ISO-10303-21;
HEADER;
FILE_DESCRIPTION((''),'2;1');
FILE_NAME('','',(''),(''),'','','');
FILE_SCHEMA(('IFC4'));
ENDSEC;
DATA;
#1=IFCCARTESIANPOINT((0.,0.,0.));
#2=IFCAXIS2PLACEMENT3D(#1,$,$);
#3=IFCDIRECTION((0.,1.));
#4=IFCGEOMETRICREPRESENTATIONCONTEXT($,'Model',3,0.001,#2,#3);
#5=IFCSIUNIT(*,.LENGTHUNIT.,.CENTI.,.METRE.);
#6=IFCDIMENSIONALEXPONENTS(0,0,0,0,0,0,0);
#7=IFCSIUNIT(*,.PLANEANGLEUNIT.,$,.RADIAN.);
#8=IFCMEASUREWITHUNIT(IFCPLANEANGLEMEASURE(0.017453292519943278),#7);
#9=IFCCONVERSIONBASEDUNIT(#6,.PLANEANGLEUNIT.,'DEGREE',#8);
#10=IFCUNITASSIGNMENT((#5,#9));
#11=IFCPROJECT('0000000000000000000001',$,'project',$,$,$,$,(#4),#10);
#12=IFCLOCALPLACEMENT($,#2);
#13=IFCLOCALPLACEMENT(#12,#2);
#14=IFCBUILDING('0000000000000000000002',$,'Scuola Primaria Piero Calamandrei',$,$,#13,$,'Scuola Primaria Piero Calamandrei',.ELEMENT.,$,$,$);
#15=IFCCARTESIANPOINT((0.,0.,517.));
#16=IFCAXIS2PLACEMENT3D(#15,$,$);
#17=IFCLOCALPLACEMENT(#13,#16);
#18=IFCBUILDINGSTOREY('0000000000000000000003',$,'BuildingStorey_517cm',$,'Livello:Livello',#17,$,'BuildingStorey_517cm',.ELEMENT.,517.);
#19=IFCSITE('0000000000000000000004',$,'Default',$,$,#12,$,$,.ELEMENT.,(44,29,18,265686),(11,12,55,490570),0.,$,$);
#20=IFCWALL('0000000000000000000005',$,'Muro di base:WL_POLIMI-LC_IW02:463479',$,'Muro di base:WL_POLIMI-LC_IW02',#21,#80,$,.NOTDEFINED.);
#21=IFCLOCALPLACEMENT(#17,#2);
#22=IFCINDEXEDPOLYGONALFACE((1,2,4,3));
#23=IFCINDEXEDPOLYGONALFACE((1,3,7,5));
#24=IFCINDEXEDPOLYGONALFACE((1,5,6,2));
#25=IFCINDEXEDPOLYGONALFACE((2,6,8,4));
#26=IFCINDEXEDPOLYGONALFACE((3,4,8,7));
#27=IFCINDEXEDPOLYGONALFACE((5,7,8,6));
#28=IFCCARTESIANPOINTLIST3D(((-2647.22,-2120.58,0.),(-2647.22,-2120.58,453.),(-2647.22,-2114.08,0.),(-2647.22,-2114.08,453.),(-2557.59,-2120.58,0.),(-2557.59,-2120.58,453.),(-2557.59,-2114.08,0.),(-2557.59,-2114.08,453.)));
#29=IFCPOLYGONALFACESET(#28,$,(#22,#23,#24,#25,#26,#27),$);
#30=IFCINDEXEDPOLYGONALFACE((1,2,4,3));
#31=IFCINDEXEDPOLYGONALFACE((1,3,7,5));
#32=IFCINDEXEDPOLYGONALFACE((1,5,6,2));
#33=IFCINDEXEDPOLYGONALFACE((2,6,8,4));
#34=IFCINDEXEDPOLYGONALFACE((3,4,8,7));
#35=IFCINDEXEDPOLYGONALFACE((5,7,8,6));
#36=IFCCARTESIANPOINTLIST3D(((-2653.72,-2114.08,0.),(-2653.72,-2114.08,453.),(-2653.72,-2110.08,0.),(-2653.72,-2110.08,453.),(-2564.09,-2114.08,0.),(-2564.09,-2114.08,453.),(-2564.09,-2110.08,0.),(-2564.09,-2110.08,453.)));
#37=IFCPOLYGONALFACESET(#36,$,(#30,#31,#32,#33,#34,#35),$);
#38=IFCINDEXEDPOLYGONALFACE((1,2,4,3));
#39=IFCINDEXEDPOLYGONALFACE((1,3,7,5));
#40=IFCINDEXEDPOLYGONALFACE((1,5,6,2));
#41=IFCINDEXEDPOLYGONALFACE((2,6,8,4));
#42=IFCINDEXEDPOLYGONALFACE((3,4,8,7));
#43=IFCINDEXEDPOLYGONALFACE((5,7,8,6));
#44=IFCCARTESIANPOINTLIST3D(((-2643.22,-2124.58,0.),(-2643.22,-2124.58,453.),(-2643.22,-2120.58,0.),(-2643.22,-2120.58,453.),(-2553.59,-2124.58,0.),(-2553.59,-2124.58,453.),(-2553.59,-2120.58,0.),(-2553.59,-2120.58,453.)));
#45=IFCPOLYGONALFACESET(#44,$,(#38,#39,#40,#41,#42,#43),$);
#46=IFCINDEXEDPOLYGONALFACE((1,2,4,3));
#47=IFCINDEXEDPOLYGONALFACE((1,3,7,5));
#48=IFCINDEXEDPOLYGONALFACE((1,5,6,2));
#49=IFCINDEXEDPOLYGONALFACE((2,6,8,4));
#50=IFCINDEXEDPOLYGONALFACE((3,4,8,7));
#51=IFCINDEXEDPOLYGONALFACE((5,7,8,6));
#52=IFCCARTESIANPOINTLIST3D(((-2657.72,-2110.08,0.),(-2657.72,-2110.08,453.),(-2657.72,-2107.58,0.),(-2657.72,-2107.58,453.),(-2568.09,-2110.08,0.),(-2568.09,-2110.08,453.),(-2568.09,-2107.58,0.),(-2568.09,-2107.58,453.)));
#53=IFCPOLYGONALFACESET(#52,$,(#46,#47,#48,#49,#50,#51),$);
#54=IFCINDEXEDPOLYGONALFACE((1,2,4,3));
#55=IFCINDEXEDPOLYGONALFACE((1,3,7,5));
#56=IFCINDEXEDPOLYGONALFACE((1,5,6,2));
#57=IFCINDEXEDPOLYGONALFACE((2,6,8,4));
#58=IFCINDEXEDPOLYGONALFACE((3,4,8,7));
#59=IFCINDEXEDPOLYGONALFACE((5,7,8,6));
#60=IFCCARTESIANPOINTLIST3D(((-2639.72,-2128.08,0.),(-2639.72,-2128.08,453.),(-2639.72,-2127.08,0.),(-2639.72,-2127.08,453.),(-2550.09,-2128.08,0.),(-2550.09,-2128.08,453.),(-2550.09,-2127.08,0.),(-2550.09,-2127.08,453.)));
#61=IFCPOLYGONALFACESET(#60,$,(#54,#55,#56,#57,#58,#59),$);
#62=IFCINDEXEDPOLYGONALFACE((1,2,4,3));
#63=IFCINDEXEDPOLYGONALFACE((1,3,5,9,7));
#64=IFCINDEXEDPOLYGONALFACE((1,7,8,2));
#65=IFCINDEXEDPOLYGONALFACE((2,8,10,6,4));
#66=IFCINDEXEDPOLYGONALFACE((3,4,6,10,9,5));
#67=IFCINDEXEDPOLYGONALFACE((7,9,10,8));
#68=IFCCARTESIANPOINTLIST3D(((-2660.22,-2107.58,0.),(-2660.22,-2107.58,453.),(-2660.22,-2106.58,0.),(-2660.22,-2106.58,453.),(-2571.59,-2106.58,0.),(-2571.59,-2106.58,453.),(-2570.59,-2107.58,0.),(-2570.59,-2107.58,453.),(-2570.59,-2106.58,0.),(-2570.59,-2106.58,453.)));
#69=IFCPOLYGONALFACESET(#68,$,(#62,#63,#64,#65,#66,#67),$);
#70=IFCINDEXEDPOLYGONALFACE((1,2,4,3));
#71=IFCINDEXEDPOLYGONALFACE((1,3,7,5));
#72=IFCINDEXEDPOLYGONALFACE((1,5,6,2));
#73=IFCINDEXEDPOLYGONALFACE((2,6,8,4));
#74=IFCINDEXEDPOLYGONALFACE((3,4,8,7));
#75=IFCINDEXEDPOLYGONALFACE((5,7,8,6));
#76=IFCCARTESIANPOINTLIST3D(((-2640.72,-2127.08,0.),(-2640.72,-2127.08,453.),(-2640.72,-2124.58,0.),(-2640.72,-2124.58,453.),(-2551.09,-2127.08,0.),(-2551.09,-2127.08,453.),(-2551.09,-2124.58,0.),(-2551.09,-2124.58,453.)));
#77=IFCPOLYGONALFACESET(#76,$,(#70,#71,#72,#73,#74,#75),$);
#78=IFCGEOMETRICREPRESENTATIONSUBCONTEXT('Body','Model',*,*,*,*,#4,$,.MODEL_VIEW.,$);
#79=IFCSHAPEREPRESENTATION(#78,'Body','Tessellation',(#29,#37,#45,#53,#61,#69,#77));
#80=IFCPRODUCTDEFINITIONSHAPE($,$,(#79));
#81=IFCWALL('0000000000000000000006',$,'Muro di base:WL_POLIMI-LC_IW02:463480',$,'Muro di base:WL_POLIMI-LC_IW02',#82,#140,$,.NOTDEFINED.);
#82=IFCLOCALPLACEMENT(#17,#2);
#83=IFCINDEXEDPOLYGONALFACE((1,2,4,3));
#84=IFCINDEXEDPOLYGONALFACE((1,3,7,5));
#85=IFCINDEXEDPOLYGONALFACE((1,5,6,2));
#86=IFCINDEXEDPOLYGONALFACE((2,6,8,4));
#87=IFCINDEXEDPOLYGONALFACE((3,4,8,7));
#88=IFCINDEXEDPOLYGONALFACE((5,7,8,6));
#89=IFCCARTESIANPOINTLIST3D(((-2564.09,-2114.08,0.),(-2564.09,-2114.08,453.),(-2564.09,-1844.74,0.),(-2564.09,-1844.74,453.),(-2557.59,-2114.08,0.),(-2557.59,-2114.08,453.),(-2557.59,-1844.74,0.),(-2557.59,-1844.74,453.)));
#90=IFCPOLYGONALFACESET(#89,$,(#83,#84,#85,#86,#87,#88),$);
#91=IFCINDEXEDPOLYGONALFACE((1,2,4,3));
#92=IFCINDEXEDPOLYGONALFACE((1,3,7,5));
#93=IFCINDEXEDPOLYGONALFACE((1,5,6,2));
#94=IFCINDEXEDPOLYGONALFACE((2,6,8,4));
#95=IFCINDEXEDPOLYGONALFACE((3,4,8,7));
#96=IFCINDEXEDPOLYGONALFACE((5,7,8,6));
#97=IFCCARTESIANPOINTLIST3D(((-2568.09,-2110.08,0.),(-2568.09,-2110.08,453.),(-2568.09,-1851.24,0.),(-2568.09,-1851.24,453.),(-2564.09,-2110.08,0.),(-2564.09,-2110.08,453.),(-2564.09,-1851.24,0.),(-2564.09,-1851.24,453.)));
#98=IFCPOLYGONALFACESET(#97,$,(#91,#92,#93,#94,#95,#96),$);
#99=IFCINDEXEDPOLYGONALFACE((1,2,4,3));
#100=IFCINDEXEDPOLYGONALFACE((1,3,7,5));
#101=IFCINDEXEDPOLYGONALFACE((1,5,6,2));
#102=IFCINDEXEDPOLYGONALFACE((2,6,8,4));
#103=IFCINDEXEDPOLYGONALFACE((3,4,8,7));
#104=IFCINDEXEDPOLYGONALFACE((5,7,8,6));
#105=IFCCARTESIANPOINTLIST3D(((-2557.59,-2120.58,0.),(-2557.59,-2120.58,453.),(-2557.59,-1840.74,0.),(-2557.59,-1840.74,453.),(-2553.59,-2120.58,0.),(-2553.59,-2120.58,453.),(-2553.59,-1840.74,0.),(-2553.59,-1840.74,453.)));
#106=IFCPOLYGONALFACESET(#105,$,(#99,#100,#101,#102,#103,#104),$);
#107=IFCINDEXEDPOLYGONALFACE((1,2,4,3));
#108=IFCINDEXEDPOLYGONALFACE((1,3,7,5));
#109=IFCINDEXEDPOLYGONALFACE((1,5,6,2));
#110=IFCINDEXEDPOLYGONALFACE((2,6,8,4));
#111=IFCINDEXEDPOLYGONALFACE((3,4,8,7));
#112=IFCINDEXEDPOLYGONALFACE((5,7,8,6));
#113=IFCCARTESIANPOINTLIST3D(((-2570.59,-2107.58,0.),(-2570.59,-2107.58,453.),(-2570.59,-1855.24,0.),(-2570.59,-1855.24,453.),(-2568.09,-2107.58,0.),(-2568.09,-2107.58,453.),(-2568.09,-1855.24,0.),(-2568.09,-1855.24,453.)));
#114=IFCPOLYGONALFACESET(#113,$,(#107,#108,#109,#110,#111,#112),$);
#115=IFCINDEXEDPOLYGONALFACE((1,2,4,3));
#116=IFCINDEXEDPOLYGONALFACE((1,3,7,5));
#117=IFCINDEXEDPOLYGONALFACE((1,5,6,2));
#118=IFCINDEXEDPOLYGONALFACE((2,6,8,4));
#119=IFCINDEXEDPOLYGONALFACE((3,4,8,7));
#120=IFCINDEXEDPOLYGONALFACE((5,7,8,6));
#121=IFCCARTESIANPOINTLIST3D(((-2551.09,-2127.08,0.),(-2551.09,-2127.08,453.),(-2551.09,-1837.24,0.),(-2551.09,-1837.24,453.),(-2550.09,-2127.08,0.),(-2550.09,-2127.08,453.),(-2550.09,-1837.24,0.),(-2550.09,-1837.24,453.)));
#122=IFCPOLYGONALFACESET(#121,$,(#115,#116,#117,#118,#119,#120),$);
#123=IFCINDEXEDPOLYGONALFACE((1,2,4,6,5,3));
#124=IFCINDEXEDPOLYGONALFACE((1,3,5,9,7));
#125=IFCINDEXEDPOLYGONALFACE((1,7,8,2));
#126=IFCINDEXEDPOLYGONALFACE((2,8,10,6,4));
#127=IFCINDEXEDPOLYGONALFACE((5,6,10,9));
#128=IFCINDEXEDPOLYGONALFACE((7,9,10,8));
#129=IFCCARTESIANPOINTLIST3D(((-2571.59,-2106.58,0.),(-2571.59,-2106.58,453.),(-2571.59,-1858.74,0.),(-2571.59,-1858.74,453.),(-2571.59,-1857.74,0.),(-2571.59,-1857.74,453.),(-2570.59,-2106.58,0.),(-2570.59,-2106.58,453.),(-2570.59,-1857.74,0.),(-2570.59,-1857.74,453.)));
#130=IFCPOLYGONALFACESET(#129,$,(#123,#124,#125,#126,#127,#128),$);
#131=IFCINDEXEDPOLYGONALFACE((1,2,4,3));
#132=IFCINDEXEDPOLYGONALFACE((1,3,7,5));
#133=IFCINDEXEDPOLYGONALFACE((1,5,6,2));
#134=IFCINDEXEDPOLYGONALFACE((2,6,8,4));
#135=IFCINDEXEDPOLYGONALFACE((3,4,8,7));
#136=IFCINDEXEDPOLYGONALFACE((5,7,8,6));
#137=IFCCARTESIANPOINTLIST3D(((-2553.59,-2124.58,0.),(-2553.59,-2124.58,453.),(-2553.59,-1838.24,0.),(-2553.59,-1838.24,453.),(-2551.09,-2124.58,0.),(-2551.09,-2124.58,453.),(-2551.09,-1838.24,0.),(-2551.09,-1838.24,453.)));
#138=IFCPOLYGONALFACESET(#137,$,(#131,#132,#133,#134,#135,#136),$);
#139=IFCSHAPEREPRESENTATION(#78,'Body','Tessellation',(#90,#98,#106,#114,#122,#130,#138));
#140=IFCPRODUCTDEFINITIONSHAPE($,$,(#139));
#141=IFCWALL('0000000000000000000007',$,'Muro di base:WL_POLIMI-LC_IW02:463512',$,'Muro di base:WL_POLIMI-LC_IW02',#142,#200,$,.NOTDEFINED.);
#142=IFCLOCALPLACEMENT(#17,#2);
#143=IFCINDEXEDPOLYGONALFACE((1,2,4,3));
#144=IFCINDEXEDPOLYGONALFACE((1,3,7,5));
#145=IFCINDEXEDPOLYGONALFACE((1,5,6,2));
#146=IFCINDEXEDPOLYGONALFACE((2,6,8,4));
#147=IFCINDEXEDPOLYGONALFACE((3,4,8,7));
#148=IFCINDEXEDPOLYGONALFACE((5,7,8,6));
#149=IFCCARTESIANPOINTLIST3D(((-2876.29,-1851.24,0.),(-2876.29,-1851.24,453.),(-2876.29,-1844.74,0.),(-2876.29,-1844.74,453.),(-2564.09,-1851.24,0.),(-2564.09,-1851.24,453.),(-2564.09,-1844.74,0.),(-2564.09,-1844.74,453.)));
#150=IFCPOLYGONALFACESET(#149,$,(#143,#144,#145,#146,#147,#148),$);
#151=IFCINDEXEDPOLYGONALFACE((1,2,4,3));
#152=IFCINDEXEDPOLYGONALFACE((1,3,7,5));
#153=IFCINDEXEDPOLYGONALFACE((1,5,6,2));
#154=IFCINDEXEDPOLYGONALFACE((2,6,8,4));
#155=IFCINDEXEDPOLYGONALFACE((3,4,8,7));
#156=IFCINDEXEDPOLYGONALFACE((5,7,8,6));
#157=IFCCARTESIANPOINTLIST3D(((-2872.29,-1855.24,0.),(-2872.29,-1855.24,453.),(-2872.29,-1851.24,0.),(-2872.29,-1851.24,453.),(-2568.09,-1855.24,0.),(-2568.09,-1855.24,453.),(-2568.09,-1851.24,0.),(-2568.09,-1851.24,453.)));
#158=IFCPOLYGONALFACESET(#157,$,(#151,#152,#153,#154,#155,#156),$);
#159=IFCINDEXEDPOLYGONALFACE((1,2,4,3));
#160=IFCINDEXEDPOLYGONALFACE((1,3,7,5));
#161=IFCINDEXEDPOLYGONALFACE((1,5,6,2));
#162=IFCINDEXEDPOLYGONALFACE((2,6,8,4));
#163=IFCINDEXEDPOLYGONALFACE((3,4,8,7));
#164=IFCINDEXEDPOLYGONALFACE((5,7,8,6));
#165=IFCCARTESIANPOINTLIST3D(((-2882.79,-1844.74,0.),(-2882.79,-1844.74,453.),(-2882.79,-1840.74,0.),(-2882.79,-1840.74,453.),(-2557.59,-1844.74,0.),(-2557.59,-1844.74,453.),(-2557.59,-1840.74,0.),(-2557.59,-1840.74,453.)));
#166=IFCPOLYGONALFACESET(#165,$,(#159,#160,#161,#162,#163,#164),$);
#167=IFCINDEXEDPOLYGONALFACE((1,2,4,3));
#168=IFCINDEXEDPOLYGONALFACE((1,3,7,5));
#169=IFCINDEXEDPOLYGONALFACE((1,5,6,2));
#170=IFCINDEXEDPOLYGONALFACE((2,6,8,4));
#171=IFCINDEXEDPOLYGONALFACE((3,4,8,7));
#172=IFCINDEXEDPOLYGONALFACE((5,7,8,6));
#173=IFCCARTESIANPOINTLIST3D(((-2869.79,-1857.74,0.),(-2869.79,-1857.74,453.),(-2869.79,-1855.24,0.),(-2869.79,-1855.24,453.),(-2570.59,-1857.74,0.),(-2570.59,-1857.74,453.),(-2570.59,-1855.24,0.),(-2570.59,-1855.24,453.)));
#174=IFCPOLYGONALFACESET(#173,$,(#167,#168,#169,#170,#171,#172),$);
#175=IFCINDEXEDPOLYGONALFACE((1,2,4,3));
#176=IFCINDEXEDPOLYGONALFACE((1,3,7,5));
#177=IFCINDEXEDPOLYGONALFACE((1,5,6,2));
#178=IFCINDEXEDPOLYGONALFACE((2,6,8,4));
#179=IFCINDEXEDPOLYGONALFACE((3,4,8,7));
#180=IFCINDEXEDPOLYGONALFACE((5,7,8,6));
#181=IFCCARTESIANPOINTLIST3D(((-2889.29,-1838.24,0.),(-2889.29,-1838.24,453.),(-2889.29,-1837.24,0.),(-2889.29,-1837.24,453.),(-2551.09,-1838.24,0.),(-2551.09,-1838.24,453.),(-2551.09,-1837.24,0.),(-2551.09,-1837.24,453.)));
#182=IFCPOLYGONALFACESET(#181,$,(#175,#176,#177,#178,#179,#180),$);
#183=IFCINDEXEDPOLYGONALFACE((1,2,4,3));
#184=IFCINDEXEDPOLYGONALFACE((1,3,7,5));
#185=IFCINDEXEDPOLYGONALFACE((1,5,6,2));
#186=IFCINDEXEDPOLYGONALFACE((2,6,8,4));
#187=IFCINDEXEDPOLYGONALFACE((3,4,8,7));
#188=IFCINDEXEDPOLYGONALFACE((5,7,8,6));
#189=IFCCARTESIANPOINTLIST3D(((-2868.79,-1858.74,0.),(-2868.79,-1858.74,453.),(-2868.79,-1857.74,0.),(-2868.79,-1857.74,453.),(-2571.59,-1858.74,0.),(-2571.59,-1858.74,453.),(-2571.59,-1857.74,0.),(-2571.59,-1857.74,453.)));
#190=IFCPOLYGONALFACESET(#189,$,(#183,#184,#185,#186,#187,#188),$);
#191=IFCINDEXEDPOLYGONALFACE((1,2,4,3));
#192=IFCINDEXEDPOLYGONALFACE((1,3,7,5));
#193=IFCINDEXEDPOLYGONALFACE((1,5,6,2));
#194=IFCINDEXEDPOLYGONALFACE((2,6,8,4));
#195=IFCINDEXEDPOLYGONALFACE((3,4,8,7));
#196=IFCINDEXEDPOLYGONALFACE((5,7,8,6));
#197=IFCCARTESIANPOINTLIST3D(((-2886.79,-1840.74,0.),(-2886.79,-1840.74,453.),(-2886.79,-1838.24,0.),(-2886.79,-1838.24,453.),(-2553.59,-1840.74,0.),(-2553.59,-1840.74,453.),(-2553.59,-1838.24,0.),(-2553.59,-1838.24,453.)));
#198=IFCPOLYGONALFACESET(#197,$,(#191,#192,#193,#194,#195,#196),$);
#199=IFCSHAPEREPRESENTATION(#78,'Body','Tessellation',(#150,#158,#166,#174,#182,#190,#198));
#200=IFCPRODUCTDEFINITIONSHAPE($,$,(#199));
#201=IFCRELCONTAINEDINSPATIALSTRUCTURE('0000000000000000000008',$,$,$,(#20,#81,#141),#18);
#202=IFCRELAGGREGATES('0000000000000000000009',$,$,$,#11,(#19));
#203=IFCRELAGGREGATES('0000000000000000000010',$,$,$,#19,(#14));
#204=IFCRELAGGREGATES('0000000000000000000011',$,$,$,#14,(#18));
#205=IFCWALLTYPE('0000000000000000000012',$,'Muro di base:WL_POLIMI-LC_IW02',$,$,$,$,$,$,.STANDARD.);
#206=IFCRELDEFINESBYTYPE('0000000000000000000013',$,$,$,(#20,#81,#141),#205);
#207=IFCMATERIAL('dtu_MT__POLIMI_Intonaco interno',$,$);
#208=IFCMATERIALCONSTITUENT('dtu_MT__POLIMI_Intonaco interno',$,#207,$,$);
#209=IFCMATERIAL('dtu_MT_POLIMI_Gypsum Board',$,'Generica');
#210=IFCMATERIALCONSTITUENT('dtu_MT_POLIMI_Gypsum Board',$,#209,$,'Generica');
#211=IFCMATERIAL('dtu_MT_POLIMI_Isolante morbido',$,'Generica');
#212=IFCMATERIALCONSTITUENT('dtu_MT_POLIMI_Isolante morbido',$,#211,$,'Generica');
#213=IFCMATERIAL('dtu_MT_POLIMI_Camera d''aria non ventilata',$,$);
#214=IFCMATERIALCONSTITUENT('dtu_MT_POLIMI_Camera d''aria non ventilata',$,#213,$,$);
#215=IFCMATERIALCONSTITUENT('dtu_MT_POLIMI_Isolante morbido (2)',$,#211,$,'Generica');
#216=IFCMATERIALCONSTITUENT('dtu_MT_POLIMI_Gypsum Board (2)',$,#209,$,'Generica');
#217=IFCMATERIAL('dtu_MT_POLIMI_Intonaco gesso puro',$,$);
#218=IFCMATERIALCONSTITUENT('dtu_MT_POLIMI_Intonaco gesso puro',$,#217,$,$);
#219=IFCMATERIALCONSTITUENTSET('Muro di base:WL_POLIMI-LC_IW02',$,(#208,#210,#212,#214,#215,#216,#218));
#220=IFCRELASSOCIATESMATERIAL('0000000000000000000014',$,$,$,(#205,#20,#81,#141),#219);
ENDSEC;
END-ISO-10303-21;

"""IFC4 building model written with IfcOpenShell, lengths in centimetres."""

from ifc_helpers import new_model, entity, si_unit, converted_unit, direction, frame, origin, place, context, subcontext, project, spatial, indexed_curve, outline, extrude, material, constituent, constituent_set, type_object, element, save


model = new_model("IFC4")

# Units and contexts
model_context = context("Model", 3, precision=0.001, world=origin(), true_north=direction((0.0, 1.0)))
body_context = subcontext(model_context, "Body", "Model", "MODEL_VIEW")
ifc_project = project(units=[si_unit("LENGTHUNIT", "METRE", prefix="CENTI"), converted_unit("PLANEANGLEUNIT", "DEGREE", entity("IfcPlaneAngleMeasure", 0.017453292519943278), si_unit("PLANEANGLEUNIT", "RADIAN"), dimensions=[0, 0, 0, 0, 0, 0, 0])], contexts=[model_context])

# Site, building, storey
site_placement = place(None, origin())
site = spatial("IfcSite", under=ifc_project, at=site_placement, Name="Default", CompositionType="ELEMENT", RefLatitude=(44, 29, 18, 265686), RefLongitude=(11, 12, 55, 490570), RefElevation=0.0)
building_placement = place(site_placement, origin())
building = spatial("IfcBuilding", under=site, at=building_placement, Name="Scuola Primaria Piero Calamandrei", LongName="Scuola Primaria Piero Calamandrei", CompositionType="ELEMENT")
storey_placement = place(building_placement, frame((0.0, 0.0, 517.0)))
storey = spatial("IfcBuildingStorey", under=building, at=storey_placement, Name="BuildingStorey_517cm", ObjectType="Livello:Livello", LongName="BuildingStorey_517cm", CompositionType="ELEMENT", Elevation=517.0)

# Shared definitions
ifc_material_1 = material(Name="dtu_MT_POLIMI_Isolante morbido", Category="Generica")
ifc_material_2 = material(Name="dtu_MT_POLIMI_Gypsum Board", Category="Generica")
ifc_material_3 = material(Name="dtu_MT__POLIMI_Intonaco interno")

# Shared definitions
ifc_constituent_1 = constituent(ifc_material_3, Name="dtu_MT__POLIMI_Intonaco interno")
ifc_constituent_2 = constituent(ifc_material_2, Name="dtu_MT_POLIMI_Gypsum Board", Category="Generica")
ifc_constituent_3 = constituent(ifc_material_1, Name="dtu_MT_POLIMI_Isolante morbido", Category="Generica")
ifc_material_4 = material(Name="dtu_MT_POLIMI_Camera d'aria non ventilata")
ifc_constituent_4 = constituent(ifc_material_4, Name="dtu_MT_POLIMI_Camera d'aria non ventilata")
ifc_constituent_5 = constituent(ifc_material_1, Name="dtu_MT_POLIMI_Isolante morbido (2)", Category="Generica")
ifc_constituent_6 = constituent(ifc_material_2, Name="dtu_MT_POLIMI_Gypsum Board (2)", Category="Generica")
ifc_material_5 = material(Name="dtu_MT_POLIMI_Intonaco gesso puro")
ifc_constituent_7 = constituent(ifc_material_5, Name="dtu_MT_POLIMI_Intonaco gesso puro")
ifc_constituent_set_1 = constituent_set(constituents=[ifc_constituent_1, ifc_constituent_2, ifc_constituent_3, ifc_constituent_4, ifc_constituent_5, ifc_constituent_6, ifc_constituent_7], Name="Muro di base:WL_POLIMI-LC_IW02")
wall_type_1 = type_object("IfcWallType", Name="Muro di base:WL_POLIMI-LC_IW02", PredefinedType="STANDARD", material=ifc_constituent_set_1)

# Walls
wall_1_placement = place(storey_placement, frame((-2639.72, -2117.33, 0.0)))
element("IfcWall", 1, at=wall_1_placement, inside=storey, type_object=wall_type_1, material=ifc_constituent_set_1, Name="Muro di base:WL_POLIMI-LC_IW02:463479", ObjectType="Muro di base:WL_POLIMI-LC_IW02", PredefinedType="NOTDEFINED", context=body_context, shape_type="SweptSolid", body=[
    extrude(outline(indexed_curve([(-44.82, -3.25), (44.82, -3.25), (44.82, 3.25), (-44.82, 3.25), (-44.82, -3.25)], self_intersect=False)), frame((37.32, 0.0, 0.0)), (0.0, 0.0, 1.0), 453.0),
    extrude(outline(indexed_curve([(-44.82, -2.0), (44.82, -2.0), (44.82, 2.0), (-44.82, 2.0), (-44.82, -2.0)], self_intersect=False)), frame((30.82, 5.25, 0.0)), (0.0, 0.0, 1.0), 453.0),
    extrude(outline(indexed_curve([(-44.82, -2.0), (44.82, -2.0), (44.82, 2.0), (-44.82, 2.0), (-44.82, -2.0)], self_intersect=False)), frame((41.32, -5.25, 0.0)), (0.0, 0.0, 1.0), 453.0),
    extrude(outline(indexed_curve([(-44.82, -1.25), (44.82, -1.25), (44.82, 1.25), (-44.82, 1.25), (-44.82, -1.25)], self_intersect=False)), frame((26.82, 8.5, 0.0)), (0.0, 0.0, 1.0), 453.0),
    extrude(outline(indexed_curve([(-0.5, -44.82), (0.5, -44.82), (0.5, 44.82), (-0.5, 44.82), (-0.5, -44.82)], self_intersect=False)), frame((44.82, -10.25, 0.0), z_axis=(0.0, 0.0, 1.0), x_axis=(0.0, 1.0, 0.0)), (0.0, 0.0, 1.0), 453.0),
    extrude(outline(indexed_curve([(-35.05, -0.4), (53.58, -0.4), (53.58, 0.6), (-36.05, 0.6), (-36.05, -0.4), (-35.05, -0.4)], self_intersect=False)), frame((33.08, 10.35, 0.0), z_axis=(0.0, 0.0, 1.0), x_axis=(-1.0, 0.0, 0.0)), (0.0, 0.0, 1.0), 453.0),
    extrude(outline(indexed_curve([(-44.82, -1.25), (44.82, -1.25), (44.82, 1.25), (-44.82, 1.25), (-44.82, -1.25)], self_intersect=False)), frame((43.82, -8.5, 0.0)), (0.0, 0.0, 1.0), 453.0),
])
wall_2_placement = place(storey_placement, frame((-2560.84, -2106.58, 0.0), z_axis=(0.0, 0.0, 1.0), x_axis=(0.0, 1.0, 0.0)))
element("IfcWall", 2, at=wall_2_placement, inside=storey, type_object=wall_type_1, material=ifc_constituent_set_1, Name="Muro di base:WL_POLIMI-LC_IW02:463480", ObjectType="Muro di base:WL_POLIMI-LC_IW02", PredefinedType="NOTDEFINED", context=body_context, shape_type="SweptSolid", body=[
    extrude(outline(indexed_curve([(-134.67, -3.25), (134.67, -3.25), (134.67, 3.25), (-134.67, 3.25), (-134.67, -3.25)], self_intersect=False)), frame((127.17, 0.0, 0.0)), (0.0, 0.0, 1.0), 453.0),
    extrude(outline(indexed_curve([(-129.42, -2.0), (129.42, -2.0), (129.42, 2.0), (-129.42, 2.0), (-129.42, -2.0)], self_intersect=False)), frame((125.92, 5.25, 0.0)), (0.0, 0.0, 1.0), 453.0),
    extrude(outline(indexed_curve([(-139.92, -2.0), (139.92, -2.0), (139.92, 2.0), (-139.92, 2.0), (-139.92, -2.0)], self_intersect=False)), frame((125.92, -5.25, 0.0)), (0.0, 0.0, 1.0), 453.0),
    extrude(outline(indexed_curve([(-126.17, -1.25), (126.17, -1.25), (126.17, 1.25), (-126.17, 1.25), (-126.17, -1.25)], self_intersect=False)), frame((125.17, 8.5, 0.0)), (0.0, 0.0, 1.0), 453.0),
    extrude(outline(indexed_curve([(-0.5, -144.92), (0.5, -144.92), (0.5, 144.92), (-0.5, 144.92), (-0.5, -144.92)], self_intersect=False)), frame((124.42, -10.25, 0.0), z_axis=(0.0, 0.0, 1.0), x_axis=(0.0, 1.0, 0.0)), (0.0, 0.0, 1.0), 453.0),
    extrude(outline(indexed_curve([(-98.74, -0.4), (149.1, -0.4), (149.1, 0.6), (-99.74, 0.6), (-99.74, -0.4), (-98.74, -0.4)], self_intersect=False)), frame((149.1, 10.35, 0.0), z_axis=(0.0, 0.0, 1.0), x_axis=(-1.0, 0.0, 0.0)), (0.0, 0.0, 1.0), 453.0),
    extrude(outline(indexed_curve([(-143.17, -1.25), (143.17, -1.25), (143.17, 1.25), (-143.17, 1.25), (-143.17, -1.25)], self_intersect=False)), frame((125.17, -8.5, 0.0)), (0.0, 0.0, 1.0), 453.0),
])

# Wall
wall_3_placement = place(storey_placement, frame((-2571.59, -1847.99, 0.0), z_axis=(0.0, 0.0, 1.0), x_axis=(-1.0, 0.0, 0.0)))
element("IfcWall", 3, at=wall_3_placement, inside=storey, type_object=wall_type_1, material=ifc_constituent_set_1, Name="Muro di base:WL_POLIMI-LC_IW02:463512", ObjectType="Muro di base:WL_POLIMI-LC_IW02", PredefinedType="NOTDEFINED", context=body_context, shape_type="SweptSolid", body=[
    extrude(outline(indexed_curve([(-156.1, -3.25), (156.1, -3.25), (156.1, 3.25), (-156.1, 3.25), (-156.1, -3.25)], self_intersect=False)), frame((148.6, 0.0, 0.0)), (0.0, 0.0, 1.0), 453.0),
    extrude(outline(indexed_curve([(-152.1, -2.0), (152.1, -2.0), (152.1, 2.0), (-152.1, 2.0), (-152.1, -2.0)], self_intersect=False)), frame((148.6, 5.25, 0.0)), (0.0, 0.0, 1.0), 453.0),
    extrude(outline(indexed_curve([(-162.6, -2.0), (162.6, -2.0), (162.6, 2.0), (-162.6, 2.0), (-162.6, -2.0)], self_intersect=False)), frame((148.6, -5.25, 0.0)), (0.0, 0.0, 1.0), 453.0),
    extrude(outline(indexed_curve([(-149.6, -1.25), (149.6, -1.25), (149.6, 1.25), (-149.6, 1.25), (-149.6, -1.25)], self_intersect=False)), frame((148.6, 8.5, 0.0)), (0.0, 0.0, 1.0), 453.0),
    extrude(outline(indexed_curve([(-0.5, -169.1), (0.5, -169.1), (0.5, 169.1), (-0.5, 169.1), (-0.5, -169.1)], self_intersect=False)), frame((148.6, -10.25, 0.0), z_axis=(0.0, 0.0, 1.0), x_axis=(0.0, 1.0, 0.0)), (0.0, 0.0, 1.0), 453.0),
    extrude(outline(indexed_curve([(-0.5, -148.6), (0.5, -148.6), (0.5, 148.6), (-0.5, 148.6), (-0.5, -148.6)], self_intersect=False)), frame((148.6, 10.25, 0.0), z_axis=(0.0, 0.0, 1.0), x_axis=(0.0, -1.0, 0.0)), (0.0, 0.0, 1.0), 453.0),
    extrude(outline(indexed_curve([(-166.6, -1.25), (166.6, -1.25), (166.6, 1.25), (-166.6, 1.25), (-166.6, -1.25)], self_intersect=False)), frame((148.6, -8.5, 0.0)), (0.0, 0.0, 1.0), 453.0),
])

save(model, "model.ifc")
